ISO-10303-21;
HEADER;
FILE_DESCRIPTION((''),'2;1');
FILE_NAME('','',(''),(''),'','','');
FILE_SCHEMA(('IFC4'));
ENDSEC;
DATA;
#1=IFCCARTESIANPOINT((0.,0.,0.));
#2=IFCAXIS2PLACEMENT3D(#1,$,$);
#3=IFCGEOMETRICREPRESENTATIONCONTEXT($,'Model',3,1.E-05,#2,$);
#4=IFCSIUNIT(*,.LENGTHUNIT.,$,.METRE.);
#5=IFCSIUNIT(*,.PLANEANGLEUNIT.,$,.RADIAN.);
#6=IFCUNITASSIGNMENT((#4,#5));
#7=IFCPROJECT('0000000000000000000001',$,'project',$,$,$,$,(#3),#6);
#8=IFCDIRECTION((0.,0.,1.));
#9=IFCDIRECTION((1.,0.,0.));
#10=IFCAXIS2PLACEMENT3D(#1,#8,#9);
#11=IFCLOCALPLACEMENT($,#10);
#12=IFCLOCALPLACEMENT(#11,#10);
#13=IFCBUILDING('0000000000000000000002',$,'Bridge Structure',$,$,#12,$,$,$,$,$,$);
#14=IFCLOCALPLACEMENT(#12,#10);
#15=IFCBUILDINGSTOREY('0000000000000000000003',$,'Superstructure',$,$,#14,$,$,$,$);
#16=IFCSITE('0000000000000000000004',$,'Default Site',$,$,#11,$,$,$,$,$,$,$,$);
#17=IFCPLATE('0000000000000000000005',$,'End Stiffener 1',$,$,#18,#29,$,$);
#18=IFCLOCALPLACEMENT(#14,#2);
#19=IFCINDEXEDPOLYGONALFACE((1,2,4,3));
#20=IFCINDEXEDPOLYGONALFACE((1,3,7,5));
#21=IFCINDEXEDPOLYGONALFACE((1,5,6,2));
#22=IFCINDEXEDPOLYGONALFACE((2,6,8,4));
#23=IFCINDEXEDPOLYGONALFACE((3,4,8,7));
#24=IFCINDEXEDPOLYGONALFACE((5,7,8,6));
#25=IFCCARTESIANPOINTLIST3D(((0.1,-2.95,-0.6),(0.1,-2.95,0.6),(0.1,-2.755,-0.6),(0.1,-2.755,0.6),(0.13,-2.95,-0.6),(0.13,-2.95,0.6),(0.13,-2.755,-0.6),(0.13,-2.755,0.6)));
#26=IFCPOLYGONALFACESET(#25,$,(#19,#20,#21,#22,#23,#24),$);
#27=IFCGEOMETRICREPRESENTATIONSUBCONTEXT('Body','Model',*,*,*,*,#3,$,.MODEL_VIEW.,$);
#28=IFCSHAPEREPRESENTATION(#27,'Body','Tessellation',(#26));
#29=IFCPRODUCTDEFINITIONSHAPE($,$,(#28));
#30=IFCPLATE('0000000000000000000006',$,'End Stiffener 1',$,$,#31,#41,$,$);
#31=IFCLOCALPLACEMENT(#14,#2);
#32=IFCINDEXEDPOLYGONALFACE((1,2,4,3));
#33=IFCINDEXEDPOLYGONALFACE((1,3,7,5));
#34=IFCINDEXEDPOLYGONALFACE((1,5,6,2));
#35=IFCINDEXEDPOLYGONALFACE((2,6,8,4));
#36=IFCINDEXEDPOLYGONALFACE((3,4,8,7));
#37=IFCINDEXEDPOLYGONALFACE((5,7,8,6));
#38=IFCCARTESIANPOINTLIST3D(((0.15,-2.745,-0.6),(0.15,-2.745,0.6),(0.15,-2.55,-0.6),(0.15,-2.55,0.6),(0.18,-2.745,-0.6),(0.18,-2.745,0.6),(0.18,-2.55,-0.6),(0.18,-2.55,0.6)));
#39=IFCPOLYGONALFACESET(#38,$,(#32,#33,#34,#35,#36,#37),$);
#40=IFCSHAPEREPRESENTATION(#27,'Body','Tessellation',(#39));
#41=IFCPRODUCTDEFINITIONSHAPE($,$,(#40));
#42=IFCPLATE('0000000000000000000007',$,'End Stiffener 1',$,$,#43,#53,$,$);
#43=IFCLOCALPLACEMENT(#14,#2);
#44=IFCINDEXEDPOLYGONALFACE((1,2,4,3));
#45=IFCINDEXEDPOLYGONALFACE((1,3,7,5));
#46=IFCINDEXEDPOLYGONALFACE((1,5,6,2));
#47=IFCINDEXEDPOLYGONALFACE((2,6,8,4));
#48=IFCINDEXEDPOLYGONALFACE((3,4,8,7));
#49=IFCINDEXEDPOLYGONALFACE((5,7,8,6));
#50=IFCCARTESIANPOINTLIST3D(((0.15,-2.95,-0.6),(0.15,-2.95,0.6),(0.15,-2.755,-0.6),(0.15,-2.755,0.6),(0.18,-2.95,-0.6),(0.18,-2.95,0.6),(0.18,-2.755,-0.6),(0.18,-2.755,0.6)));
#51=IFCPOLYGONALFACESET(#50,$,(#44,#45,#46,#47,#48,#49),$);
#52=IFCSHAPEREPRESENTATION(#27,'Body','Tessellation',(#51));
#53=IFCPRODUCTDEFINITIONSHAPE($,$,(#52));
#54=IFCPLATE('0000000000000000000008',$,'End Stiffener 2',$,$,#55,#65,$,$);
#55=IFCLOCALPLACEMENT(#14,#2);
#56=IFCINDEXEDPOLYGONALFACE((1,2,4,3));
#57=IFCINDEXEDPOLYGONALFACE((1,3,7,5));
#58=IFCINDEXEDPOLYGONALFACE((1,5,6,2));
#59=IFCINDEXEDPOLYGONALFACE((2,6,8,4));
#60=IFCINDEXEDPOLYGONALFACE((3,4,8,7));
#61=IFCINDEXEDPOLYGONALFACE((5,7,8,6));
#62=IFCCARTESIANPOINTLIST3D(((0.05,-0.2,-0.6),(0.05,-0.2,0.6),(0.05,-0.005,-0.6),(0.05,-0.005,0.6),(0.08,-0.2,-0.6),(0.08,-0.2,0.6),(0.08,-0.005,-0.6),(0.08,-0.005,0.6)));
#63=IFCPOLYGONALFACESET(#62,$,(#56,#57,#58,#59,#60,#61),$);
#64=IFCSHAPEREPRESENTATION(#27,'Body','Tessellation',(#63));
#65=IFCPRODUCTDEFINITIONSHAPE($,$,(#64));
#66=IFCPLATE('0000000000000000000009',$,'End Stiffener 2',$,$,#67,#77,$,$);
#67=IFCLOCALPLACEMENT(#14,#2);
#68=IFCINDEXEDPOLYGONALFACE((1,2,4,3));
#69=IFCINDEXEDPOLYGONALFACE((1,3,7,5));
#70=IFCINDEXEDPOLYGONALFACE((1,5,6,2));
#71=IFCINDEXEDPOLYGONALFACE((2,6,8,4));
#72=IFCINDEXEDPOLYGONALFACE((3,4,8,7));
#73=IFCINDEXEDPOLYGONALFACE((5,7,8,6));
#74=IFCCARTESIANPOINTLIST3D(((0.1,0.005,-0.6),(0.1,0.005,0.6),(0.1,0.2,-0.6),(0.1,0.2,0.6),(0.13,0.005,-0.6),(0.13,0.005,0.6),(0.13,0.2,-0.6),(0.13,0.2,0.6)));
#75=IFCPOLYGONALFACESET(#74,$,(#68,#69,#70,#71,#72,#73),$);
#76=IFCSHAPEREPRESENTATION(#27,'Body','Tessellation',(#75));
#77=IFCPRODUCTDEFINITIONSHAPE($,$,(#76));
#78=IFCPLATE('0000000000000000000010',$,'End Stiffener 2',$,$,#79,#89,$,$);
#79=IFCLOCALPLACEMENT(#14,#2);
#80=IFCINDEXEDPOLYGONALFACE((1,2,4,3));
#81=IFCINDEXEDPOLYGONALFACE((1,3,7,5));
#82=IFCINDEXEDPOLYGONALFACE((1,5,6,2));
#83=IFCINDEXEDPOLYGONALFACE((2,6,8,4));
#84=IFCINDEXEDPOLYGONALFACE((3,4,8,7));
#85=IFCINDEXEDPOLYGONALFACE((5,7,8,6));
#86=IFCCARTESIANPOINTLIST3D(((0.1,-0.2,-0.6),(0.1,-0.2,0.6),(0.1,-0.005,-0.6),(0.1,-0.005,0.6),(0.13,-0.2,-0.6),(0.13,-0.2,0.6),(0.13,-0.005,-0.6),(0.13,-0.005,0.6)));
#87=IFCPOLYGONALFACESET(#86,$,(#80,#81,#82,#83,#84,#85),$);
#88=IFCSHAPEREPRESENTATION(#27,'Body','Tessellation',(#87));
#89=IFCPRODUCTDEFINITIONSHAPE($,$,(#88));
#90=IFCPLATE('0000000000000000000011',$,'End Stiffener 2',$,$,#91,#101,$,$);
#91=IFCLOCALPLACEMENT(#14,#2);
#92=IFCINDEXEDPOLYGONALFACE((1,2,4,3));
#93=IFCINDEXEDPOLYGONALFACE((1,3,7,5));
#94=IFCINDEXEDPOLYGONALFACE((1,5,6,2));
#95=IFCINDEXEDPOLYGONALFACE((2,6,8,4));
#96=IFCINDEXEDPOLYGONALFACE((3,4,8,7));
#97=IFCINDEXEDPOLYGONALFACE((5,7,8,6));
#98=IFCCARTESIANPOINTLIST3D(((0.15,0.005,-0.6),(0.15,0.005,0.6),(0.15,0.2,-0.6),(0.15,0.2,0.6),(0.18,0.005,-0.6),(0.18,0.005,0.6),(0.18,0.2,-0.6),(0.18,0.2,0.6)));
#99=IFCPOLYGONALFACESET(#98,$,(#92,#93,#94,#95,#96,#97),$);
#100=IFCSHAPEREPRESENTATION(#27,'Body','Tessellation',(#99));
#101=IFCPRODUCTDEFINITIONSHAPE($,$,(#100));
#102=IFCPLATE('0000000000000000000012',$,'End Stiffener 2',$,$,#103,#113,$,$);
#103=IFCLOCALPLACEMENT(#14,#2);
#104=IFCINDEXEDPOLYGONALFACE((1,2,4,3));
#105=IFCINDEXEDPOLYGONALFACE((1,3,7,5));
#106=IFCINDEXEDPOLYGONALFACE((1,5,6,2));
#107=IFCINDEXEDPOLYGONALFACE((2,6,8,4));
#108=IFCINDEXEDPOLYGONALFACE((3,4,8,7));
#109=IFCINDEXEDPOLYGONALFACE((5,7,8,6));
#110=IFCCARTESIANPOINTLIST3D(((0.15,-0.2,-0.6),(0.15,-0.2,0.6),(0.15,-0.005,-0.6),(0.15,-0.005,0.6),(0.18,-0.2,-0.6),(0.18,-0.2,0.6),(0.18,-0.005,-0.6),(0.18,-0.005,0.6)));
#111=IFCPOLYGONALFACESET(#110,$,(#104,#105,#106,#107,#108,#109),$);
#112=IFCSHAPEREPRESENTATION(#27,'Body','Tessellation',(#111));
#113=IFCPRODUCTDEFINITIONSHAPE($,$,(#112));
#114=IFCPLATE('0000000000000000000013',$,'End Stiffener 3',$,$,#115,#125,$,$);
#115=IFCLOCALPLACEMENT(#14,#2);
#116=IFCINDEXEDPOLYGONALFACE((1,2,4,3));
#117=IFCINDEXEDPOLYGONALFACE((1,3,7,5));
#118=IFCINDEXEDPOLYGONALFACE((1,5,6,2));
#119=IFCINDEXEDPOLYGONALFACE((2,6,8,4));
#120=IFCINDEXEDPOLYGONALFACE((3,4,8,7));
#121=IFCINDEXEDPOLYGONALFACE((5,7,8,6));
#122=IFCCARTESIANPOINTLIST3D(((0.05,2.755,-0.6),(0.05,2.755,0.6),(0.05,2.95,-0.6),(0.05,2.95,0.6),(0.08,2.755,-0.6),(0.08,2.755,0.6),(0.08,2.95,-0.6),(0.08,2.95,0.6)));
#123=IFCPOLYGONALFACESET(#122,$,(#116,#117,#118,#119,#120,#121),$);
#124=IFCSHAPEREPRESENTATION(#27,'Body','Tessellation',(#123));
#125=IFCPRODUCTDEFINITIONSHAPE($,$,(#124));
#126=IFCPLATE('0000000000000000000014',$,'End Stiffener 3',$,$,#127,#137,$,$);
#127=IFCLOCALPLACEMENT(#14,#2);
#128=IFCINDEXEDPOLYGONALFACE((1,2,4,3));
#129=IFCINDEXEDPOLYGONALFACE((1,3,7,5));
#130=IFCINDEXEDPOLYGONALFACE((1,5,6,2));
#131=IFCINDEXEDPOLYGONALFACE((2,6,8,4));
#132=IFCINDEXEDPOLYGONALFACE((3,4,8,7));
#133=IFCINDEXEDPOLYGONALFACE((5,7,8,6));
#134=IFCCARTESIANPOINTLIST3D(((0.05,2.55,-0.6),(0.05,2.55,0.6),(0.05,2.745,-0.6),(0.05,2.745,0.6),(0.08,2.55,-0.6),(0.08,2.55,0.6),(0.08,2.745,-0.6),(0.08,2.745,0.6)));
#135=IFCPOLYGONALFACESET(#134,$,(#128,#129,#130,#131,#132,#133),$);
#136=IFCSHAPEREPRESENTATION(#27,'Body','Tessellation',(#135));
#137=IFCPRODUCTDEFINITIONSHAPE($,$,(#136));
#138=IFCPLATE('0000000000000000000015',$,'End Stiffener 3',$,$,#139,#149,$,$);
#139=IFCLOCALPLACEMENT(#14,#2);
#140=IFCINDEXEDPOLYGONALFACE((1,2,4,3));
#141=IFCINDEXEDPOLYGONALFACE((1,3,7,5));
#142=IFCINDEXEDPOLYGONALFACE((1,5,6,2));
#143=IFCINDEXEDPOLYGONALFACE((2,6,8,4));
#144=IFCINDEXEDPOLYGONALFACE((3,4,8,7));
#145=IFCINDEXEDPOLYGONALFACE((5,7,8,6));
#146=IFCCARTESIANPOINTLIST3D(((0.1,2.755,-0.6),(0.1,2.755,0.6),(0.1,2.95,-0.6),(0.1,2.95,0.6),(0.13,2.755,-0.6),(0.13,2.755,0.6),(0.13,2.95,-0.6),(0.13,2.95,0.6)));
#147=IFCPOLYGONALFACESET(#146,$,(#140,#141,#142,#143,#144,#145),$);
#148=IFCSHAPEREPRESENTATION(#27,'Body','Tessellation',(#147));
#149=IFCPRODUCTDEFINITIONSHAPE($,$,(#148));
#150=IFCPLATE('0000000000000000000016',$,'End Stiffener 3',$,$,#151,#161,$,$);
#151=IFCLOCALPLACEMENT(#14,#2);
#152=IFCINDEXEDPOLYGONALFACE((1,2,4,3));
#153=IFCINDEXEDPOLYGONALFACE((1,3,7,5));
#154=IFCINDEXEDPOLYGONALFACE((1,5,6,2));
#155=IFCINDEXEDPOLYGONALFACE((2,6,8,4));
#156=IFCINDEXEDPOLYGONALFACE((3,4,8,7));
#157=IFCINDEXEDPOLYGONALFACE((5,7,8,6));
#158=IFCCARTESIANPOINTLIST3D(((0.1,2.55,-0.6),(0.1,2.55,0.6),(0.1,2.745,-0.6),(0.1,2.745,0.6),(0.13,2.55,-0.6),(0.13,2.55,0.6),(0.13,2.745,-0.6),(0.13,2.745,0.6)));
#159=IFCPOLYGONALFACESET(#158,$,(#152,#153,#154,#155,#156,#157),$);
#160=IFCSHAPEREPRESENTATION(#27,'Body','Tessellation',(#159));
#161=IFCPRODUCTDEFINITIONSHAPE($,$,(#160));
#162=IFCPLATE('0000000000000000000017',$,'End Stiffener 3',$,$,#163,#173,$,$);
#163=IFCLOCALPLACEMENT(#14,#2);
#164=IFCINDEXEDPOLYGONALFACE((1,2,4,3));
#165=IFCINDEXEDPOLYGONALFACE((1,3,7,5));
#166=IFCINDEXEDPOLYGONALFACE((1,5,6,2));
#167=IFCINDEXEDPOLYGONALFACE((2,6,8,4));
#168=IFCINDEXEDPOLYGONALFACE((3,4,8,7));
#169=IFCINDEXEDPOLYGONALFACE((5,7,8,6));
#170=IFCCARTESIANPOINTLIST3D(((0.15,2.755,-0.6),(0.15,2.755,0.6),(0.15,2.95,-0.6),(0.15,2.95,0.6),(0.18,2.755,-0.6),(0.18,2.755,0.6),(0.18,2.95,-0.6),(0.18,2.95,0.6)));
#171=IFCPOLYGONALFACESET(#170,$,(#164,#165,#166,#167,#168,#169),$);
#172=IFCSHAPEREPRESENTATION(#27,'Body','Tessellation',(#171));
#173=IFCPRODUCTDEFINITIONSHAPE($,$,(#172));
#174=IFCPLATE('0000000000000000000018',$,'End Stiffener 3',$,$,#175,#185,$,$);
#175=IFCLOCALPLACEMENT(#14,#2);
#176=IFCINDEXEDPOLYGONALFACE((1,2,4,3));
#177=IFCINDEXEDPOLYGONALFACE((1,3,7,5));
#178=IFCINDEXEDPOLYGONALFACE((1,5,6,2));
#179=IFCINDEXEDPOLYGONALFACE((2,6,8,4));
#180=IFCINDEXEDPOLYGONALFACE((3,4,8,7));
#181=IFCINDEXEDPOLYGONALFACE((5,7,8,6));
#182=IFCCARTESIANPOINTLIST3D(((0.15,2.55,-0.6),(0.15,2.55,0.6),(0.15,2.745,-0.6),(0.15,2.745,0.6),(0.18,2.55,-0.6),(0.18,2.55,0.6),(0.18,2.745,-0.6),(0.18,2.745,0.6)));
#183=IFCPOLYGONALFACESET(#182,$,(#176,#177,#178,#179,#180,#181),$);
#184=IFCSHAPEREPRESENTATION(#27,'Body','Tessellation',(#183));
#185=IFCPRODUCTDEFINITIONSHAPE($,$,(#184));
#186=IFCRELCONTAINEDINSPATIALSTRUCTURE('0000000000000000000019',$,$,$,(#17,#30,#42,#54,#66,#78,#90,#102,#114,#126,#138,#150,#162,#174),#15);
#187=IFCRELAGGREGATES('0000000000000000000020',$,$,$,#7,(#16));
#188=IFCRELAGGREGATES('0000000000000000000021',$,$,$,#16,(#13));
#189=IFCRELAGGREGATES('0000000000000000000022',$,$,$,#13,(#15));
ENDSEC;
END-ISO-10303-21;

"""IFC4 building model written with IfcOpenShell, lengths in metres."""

from ifc_helpers import new_model, si_unit, frame, origin, origin_with_axes, origin_2d_with_axis, place, context, subcontext, project, spatial, rectangle, extrude, element, save


model = new_model("IFC4")

# Units and contexts
model_context = context("Model", 3, precision=1e-05, world=origin())
body_context = subcontext(model_context, "Body", "Model", "MODEL_VIEW")
ifc_project = project(units=[si_unit("LENGTHUNIT", "METRE"), si_unit("PLANEANGLEUNIT", "RADIAN")], contexts=[model_context])

# Site, building, storey
site_placement = place(None, origin_with_axes())
site = spatial("IfcSite", under=ifc_project, at=site_placement, Name="Default Site")
building_placement = place(site_placement, origin_with_axes())
building = spatial("IfcBuilding", under=site, at=building_placement, Name="Bridge Structure")
storey_placement = place(building_placement, origin_with_axes())
storey = spatial("IfcBuildingStorey", under=building, at=storey_placement, Name="Superstructure")

# Plates
for number, where, z_axis, x_axis, name in (
    (1, (0.115, -2.8525, -0.6), (0.0, 0.0, 1.0), (1.0, 0.0, 0.0), "End Stiffener 1"),
    (2, (0.165, -2.6475, -0.6), (0.0, 0.0, 1.0), (1.0, 0.0, 0.0), "End Stiffener 1"),
    (3, (0.165, -2.8525, -0.6), (0.0, 0.0, 1.0), (1.0, 0.0, 0.0), "End Stiffener 1"),
    (4, (0.065, -0.1025, -0.6), (0.0, 0.0, 1.0), (1.0, 0.0, 0.0), "End Stiffener 2"),
    (5, (0.115, 0.1025, -0.6), (0.0, 0.0, 1.0), (1.0, 0.0, 0.0), "End Stiffener 2"),
    (6, (0.115, -0.1025, -0.6), (0.0, 0.0, 1.0), (1.0, 0.0, 0.0), "End Stiffener 2"),
    (7, (0.165, 0.1025, -0.6), (0.0, 0.0, 1.0), (1.0, 0.0, 0.0), "End Stiffener 2"),
    (8, (0.165, -0.1025, -0.6), (0.0, 0.0, 1.0), (1.0, 0.0, 0.0), "End Stiffener 2"),
    (9, (0.065, 2.8525, -0.6), (0.0, 0.0, 1.0), (1.0, 0.0, 0.0), "End Stiffener 3"),
    (10, (0.065, 2.6475, -0.6), (0.0, 0.0, 1.0), (1.0, 0.0, 0.0), "End Stiffener 3"),
    (11, (0.115, 2.8525, -0.6), (0.0, 0.0, 1.0), (1.0, 0.0, 0.0), "End Stiffener 3"),
    (12, (0.115, 2.6475, -0.6), (0.0, 0.0, 1.0), (1.0, 0.0, 0.0), "End Stiffener 3"),
    (13, (0.165, 2.8525, -0.6), (0.0, 0.0, 1.0), (1.0, 0.0, 0.0), "End Stiffener 3"),
    (14, (0.165, 2.6475, -0.6), (0.0, 0.0, 1.0), (1.0, 0.0, 0.0), "End Stiffener 3"),
):
    element("IfcPlate", number, at=place(storey_placement, frame(where, z_axis=z_axis, x_axis=x_axis)), inside=storey, Name=name, context=body_context, shape_type="SweptSolid", body=[
        extrude(rectangle(XDim=0.03, YDim=0.195, at=origin_2d_with_axis()), origin_with_axes(), (0.0, 0.0, 1.0), 1.2),
    ])

save(model, "model.ifc")
